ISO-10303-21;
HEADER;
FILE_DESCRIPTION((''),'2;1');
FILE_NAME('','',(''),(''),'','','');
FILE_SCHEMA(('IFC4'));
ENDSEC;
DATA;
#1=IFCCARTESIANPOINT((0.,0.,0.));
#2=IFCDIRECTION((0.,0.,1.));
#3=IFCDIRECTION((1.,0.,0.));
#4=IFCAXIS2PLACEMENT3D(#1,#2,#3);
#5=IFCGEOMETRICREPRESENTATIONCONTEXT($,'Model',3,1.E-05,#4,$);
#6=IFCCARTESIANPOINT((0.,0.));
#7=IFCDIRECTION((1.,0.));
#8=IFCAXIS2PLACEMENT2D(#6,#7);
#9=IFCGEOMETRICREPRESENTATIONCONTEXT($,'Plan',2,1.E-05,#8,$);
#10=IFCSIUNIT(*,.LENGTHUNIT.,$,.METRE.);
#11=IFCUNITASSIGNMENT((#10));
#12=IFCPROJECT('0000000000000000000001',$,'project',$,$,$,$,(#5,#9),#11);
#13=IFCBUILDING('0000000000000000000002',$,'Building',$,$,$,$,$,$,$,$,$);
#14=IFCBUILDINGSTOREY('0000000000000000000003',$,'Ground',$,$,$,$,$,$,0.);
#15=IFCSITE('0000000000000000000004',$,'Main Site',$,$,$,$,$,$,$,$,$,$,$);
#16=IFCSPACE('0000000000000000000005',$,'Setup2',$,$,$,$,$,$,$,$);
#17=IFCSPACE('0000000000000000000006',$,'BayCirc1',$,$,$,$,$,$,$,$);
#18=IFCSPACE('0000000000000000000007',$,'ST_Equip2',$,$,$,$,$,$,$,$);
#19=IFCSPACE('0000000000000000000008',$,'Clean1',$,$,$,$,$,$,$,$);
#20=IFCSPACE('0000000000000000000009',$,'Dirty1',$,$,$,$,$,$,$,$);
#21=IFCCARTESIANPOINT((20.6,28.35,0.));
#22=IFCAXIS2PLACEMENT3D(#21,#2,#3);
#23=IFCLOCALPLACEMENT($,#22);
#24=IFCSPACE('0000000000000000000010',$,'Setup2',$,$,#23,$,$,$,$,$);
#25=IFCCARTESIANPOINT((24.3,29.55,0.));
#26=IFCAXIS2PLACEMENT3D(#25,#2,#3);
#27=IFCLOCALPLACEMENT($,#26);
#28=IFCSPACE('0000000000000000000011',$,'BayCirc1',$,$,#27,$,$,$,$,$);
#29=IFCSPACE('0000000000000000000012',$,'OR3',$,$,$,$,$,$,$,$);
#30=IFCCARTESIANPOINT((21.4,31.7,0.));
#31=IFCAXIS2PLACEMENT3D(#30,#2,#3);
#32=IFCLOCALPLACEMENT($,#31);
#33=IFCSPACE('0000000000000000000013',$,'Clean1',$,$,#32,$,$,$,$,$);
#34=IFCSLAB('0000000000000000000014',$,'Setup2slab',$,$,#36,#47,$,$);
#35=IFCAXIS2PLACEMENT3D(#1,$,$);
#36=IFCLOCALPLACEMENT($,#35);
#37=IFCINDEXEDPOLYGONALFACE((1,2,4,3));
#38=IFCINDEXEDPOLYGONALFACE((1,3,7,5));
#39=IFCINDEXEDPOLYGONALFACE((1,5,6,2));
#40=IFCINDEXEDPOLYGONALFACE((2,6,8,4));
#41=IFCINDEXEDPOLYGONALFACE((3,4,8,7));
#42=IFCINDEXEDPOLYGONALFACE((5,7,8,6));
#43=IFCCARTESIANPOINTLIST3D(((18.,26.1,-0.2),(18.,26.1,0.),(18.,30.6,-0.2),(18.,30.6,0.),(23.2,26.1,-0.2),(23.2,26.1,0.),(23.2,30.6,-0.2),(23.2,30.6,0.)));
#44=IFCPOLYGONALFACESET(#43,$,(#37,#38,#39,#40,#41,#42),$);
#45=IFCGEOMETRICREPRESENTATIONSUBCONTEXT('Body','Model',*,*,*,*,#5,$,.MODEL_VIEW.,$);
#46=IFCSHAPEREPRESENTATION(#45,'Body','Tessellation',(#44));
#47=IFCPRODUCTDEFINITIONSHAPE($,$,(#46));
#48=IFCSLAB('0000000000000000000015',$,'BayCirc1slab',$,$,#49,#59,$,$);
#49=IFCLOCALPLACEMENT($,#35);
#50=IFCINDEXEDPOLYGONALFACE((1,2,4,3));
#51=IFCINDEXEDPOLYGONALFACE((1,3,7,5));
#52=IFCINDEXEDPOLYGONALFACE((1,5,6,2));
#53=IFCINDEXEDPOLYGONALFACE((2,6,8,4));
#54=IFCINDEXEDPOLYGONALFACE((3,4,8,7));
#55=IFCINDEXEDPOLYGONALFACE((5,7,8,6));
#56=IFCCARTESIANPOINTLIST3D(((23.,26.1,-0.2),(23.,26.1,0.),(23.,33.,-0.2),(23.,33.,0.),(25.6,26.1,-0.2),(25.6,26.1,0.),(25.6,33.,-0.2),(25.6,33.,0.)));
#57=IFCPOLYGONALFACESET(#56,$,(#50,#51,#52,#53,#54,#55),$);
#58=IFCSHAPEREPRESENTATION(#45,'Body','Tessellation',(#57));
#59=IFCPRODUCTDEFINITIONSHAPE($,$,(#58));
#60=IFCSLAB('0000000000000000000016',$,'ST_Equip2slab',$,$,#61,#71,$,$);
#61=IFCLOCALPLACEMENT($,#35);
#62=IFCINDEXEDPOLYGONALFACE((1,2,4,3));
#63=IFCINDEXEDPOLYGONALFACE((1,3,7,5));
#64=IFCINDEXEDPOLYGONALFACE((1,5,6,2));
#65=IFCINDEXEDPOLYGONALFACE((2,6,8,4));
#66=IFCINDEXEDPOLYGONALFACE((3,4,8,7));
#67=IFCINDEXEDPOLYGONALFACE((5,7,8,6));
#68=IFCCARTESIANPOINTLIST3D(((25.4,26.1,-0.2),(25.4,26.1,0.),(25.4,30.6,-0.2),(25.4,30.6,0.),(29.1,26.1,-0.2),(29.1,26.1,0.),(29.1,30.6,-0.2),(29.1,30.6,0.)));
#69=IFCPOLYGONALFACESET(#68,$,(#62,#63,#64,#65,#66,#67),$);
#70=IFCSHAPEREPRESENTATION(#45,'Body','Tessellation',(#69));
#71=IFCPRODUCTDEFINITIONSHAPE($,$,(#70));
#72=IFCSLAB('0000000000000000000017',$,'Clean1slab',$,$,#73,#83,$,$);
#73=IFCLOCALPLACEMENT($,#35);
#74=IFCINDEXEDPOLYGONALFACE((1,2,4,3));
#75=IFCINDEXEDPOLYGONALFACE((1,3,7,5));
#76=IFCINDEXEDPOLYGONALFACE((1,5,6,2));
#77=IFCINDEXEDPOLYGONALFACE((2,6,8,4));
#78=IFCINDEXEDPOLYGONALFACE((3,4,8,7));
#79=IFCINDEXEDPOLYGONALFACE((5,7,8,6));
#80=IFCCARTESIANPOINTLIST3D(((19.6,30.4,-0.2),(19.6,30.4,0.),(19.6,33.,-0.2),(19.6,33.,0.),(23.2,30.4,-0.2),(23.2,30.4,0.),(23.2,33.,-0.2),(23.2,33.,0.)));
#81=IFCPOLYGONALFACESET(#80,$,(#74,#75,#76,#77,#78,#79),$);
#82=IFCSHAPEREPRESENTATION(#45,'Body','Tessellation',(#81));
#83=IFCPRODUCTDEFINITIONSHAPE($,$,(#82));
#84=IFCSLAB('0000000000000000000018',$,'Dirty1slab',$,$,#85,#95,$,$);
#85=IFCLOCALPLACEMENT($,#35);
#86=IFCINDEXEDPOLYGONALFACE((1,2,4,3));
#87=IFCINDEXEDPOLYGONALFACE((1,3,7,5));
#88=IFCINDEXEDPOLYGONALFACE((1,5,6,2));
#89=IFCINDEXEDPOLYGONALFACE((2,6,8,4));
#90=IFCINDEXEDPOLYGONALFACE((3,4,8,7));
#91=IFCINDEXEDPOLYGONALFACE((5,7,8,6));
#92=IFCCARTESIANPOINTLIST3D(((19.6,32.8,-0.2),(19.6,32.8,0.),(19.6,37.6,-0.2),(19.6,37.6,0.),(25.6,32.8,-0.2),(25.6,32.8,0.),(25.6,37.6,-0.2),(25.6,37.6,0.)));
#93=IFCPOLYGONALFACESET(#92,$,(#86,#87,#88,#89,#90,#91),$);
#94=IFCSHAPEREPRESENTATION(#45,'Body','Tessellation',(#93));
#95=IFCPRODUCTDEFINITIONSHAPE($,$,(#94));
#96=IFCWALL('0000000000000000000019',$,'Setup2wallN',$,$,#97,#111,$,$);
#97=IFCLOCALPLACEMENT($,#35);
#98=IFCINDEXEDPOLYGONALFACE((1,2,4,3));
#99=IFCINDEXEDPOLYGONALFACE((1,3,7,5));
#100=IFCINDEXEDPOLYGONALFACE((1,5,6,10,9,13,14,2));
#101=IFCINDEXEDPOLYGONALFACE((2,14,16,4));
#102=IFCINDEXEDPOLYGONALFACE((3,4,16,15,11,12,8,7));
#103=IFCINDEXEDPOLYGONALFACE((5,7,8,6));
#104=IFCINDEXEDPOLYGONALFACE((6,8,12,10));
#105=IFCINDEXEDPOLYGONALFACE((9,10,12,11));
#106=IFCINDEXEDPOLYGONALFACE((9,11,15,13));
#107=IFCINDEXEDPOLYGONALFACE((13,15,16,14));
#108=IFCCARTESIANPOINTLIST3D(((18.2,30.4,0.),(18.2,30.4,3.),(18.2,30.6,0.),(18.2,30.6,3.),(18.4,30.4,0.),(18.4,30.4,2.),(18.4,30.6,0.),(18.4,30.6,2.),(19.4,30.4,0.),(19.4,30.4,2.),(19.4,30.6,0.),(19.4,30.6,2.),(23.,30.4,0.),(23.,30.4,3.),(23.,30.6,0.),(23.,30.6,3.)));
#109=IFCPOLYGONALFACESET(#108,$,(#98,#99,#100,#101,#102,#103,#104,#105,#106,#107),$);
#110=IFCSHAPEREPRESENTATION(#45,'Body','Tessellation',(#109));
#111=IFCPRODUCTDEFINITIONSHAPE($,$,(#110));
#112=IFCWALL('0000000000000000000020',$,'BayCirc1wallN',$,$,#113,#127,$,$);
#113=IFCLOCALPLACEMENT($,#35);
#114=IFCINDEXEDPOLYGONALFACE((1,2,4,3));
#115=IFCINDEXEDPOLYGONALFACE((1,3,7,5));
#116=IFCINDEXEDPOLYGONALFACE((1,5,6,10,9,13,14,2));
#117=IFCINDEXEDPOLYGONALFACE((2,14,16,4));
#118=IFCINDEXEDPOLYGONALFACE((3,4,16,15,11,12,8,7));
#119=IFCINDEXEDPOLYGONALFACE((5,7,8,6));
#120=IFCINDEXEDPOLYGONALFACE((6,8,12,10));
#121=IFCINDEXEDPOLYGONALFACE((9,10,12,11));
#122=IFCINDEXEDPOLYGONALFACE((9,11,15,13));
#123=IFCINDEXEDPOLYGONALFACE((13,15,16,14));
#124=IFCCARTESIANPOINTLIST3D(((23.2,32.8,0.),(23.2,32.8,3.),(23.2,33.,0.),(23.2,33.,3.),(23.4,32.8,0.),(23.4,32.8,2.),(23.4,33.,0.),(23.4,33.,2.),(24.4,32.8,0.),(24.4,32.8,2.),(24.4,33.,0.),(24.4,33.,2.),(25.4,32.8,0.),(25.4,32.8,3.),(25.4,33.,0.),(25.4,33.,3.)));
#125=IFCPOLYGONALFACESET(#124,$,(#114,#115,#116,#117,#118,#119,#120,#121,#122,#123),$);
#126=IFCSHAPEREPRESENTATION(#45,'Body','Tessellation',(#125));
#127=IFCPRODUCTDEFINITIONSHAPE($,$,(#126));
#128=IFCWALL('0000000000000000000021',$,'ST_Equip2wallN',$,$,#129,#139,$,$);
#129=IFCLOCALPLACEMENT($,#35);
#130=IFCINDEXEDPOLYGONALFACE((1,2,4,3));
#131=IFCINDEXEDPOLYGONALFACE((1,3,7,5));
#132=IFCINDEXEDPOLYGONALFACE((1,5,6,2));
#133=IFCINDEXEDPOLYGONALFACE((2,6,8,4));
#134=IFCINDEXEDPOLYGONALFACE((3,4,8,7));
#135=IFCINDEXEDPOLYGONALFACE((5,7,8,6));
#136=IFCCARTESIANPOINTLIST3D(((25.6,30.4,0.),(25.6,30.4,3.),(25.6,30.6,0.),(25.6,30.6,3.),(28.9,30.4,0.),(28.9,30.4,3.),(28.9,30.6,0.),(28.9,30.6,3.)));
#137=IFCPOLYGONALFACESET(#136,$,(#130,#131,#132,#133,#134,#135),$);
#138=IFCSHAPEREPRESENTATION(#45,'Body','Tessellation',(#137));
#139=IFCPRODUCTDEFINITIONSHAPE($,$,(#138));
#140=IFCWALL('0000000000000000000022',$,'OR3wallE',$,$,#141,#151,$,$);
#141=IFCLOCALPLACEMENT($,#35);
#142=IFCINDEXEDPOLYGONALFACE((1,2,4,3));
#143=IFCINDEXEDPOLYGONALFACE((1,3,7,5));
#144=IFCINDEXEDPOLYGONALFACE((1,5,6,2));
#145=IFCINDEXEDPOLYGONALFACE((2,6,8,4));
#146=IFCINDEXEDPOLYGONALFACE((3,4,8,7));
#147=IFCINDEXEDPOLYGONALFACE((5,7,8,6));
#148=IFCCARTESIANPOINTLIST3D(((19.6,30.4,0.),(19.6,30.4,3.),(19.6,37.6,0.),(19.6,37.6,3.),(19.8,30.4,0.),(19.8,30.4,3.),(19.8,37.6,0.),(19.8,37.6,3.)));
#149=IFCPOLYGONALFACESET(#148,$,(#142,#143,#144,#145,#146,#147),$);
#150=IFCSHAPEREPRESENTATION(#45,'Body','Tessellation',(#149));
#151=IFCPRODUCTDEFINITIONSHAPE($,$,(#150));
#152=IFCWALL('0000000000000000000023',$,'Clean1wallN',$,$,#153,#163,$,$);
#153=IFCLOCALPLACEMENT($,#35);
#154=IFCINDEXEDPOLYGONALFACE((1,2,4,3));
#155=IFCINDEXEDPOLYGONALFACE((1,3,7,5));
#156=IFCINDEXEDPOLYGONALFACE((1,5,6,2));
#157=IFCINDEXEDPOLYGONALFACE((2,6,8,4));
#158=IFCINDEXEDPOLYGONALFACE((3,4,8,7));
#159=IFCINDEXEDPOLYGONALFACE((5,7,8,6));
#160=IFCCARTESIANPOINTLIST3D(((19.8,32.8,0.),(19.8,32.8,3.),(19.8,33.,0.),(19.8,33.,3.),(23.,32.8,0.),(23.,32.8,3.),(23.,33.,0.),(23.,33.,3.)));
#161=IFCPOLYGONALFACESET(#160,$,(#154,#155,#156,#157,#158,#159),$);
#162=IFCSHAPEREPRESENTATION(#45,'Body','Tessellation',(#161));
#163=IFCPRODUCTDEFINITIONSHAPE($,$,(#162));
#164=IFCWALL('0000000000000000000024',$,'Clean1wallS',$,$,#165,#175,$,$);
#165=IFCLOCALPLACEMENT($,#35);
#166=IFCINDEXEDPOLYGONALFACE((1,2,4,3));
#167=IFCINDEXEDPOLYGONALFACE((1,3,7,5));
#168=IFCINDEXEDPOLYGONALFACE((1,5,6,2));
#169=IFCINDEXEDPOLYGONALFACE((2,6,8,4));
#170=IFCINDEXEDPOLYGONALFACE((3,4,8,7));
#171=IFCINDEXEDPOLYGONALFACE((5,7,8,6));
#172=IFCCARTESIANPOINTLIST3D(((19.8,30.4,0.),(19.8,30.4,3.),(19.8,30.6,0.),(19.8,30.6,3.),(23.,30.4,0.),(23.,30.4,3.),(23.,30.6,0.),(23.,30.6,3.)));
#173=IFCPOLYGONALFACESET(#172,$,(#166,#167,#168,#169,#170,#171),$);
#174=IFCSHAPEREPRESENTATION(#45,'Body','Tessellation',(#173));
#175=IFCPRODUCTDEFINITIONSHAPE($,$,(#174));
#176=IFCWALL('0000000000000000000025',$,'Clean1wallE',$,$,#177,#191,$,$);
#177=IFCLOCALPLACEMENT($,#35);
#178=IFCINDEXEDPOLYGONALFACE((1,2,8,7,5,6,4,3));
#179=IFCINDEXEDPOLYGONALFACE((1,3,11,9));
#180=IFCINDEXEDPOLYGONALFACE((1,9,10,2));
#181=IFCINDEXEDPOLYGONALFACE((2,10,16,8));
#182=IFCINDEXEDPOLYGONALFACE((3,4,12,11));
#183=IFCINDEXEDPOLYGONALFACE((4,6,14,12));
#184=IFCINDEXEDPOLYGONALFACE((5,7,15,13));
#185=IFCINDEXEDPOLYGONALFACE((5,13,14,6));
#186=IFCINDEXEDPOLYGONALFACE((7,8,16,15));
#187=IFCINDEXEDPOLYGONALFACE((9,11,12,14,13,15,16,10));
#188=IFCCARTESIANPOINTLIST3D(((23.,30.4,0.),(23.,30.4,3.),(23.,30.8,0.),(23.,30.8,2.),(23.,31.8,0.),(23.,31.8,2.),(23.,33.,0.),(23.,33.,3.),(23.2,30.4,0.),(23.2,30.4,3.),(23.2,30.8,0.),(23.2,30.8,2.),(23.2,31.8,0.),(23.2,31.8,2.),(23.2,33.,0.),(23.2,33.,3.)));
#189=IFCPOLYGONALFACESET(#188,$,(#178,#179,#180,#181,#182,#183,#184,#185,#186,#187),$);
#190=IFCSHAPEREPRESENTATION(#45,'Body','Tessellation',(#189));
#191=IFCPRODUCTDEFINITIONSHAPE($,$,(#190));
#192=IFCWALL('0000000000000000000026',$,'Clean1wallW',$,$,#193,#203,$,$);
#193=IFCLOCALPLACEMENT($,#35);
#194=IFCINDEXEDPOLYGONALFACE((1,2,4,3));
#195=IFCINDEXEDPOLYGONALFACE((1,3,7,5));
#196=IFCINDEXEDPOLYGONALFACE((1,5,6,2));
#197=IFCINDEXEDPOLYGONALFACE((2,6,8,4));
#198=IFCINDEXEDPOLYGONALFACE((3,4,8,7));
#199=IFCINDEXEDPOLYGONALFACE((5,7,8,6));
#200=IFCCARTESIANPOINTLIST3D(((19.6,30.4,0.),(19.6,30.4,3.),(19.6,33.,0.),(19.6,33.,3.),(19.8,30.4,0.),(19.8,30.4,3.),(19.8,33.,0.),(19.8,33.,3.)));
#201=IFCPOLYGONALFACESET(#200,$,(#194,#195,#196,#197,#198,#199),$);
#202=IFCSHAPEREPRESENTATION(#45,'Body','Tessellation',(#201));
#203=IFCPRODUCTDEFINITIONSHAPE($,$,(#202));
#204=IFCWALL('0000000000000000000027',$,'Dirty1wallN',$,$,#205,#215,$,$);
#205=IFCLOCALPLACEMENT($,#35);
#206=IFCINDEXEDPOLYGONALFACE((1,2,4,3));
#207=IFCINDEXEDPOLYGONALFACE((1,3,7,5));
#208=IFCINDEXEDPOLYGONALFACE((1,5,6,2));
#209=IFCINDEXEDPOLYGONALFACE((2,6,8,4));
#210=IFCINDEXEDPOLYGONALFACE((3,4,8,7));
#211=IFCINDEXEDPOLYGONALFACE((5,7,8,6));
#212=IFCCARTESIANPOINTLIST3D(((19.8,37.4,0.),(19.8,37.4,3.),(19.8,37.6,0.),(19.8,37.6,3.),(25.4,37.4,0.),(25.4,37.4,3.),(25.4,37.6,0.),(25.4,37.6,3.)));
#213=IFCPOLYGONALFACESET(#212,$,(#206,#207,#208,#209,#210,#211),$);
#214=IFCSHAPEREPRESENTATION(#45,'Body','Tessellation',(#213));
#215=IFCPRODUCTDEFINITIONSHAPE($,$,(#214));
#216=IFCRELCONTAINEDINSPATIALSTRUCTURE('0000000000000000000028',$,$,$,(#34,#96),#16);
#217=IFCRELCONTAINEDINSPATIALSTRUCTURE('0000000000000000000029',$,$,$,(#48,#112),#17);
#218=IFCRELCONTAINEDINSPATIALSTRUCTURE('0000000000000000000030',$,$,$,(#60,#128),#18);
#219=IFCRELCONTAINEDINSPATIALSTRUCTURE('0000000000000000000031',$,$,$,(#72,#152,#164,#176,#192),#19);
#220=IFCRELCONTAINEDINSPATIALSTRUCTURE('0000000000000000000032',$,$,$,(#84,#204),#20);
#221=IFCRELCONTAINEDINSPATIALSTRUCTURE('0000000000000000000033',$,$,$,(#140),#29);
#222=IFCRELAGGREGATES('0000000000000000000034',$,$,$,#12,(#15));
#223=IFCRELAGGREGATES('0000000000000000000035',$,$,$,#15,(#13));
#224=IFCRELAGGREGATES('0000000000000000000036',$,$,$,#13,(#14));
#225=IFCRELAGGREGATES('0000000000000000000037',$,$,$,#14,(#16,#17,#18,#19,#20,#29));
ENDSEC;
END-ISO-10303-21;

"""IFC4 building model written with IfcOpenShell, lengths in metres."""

from ifc_helpers import new_model, si_unit, frame, origin_with_axes, origin_2d_with_axis, place, context, subcontext, project, spatial, indexed_curve, rectangle, outline, extrude, element, save


model = new_model("IFC4")

# Units and contexts
model_context = context("Model", 3, precision=1e-05, world=origin_with_axes())
plan_context = context("Plan", 2, precision=1e-05, world=origin_2d_with_axis())
body_context = subcontext(model_context, "Body", "Model", "MODEL_VIEW")
ifc_project = project(units=[si_unit("LENGTHUNIT", "METRE")], contexts=[model_context, plan_context])

# Site, building, storey, space
site = spatial("IfcSite", under=ifc_project, Name="Main Site")
building = spatial("IfcBuilding", under=site, Name="Building")
storey = spatial("IfcBuildingStorey", under=building, Name="Ground", Elevation=0.0)
space_1 = spatial("IfcSpace", under=storey, Name="Setup2")

# Slab
slab_1_placement = place(None, frame((20.6, 28.35, -0.2), z_axis=(0.0, 0.0, 1.0), x_axis=(1.0, 0.0, 0.0)))
element("IfcSlab", 1, at=slab_1_placement, inside=space_1, Name="Setup2slab", context=body_context, shape_type="SweptSolid", body=[
    extrude(rectangle(XDim=5.2, YDim=4.5), origin_with_axes(), (0.0, 0.0, 1.0), 0.2),
])

# Shared definitions
space_2 = spatial("IfcSpace", under=storey, Name="BayCirc1")

# Slab
slab_2_placement = place(None, frame((24.3, 29.55, -0.2), z_axis=(0.0, 0.0, 1.0), x_axis=(1.0, 0.0, 0.0)))
element("IfcSlab", 2, at=slab_2_placement, inside=space_2, Name="BayCirc1slab", context=body_context, shape_type="SweptSolid", body=[
    extrude(rectangle(XDim=2.6, YDim=6.9), origin_with_axes(), (0.0, 0.0, 1.0), 0.2),
])

# Shared definitions
space_3 = spatial("IfcSpace", under=storey, Name="ST_Equip2")

# Slab
slab_3_placement = place(None, frame((27.25, 28.35, -0.2), z_axis=(0.0, 0.0, 1.0), x_axis=(1.0, 0.0, 0.0)))
element("IfcSlab", 3, at=slab_3_placement, inside=space_3, Name="ST_Equip2slab", context=body_context, shape_type="SweptSolid", body=[
    extrude(rectangle(XDim=3.7, YDim=4.5), origin_with_axes(), (0.0, 0.0, 1.0), 0.2),
])

# Shared definitions
space_4 = spatial("IfcSpace", under=storey, Name="Clean1")

# Slab
slab_4_placement = place(None, frame((21.4, 31.7, -0.2), z_axis=(0.0, 0.0, 1.0), x_axis=(1.0, 0.0, 0.0)))
element("IfcSlab", 4, at=slab_4_placement, inside=space_4, Name="Clean1slab", context=body_context, shape_type="SweptSolid", body=[
    extrude(rectangle(XDim=3.6, YDim=2.6), origin_with_axes(), (0.0, 0.0, 1.0), 0.2),
])

# Shared definitions
space_5 = spatial("IfcSpace", under=storey, Name="Dirty1")

# Slab
slab_5_placement = place(None, frame((22.6, 35.2, -0.2), z_axis=(0.0, 0.0, 1.0), x_axis=(1.0, 0.0, 0.0)))
element("IfcSlab", 5, at=slab_5_placement, inside=space_5, Name="Dirty1slab", context=body_context, shape_type="SweptSolid", body=[
    extrude(rectangle(XDim=6.0, YDim=4.8), origin_with_axes(), (0.0, 0.0, 1.0), 0.2),
])

# Wall
wall_1_placement = place(None, frame((18.2, 30.4, 0.0), z_axis=(0.0, 0.0, 1.0), x_axis=(1.0, 0.0, 0.0)))
wall_1 = element("IfcWall", 6, at=wall_1_placement, inside=space_1, Name="Setup2wallN", context=body_context, shape_type="SweptSolid", body=[
    extrude(outline(indexed_curve([(0.0, 0.0), (0.0, 0.2), (4.8, 0.2), (4.8, 0.0), (0.0, 0.0)], self_intersect=False)), origin_with_axes(), (0.0, 0.0, 1.0), 3.0),
])

# Shared definitions
space_6_placement = place(None, frame((20.6, 28.35, 0.0), z_axis=(0.0, 0.0, 1.0), x_axis=(1.0, 0.0, 0.0)))
space_6 = spatial("IfcSpace", at=space_6_placement, Name="Setup2")

# Opening
opening_1_placement = place(wall_1_placement, frame((0.2, 0.0, 0.0), z_axis=(0.0, 0.0, 1.0), x_axis=(1.0, 0.0, 0.0)))
element("IfcOpeningElement", 7, at=opening_1_placement, inside=space_6, cuts=wall_1, context=body_context, shape_type="SweptSolid", body=[
    extrude(outline(indexed_curve([(0.0, 0.0), (0.0, 0.4), (1.0, 0.4), (1.0, 0.0), (0.0, 0.0)], self_intersect=False)), origin_with_axes(), (0.0, 0.0, 1.0), 2.0),
])

# Wall
wall_2_placement = place(None, frame((23.2, 32.8, 0.0), z_axis=(0.0, 0.0, 1.0), x_axis=(1.0, 0.0, 0.0)))
wall_2 = element("IfcWall", 8, at=wall_2_placement, inside=space_2, Name="BayCirc1wallN", context=body_context, shape_type="SweptSolid", body=[
    extrude(outline(indexed_curve([(0.0, 0.0), (0.0, 0.2), (2.2, 0.2), (2.2, 0.0), (0.0, 0.0)], self_intersect=False)), origin_with_axes(), (0.0, 0.0, 1.0), 3.0),
])

# Shared definitions
space_7_placement = place(None, frame((24.3, 29.55, 0.0), z_axis=(0.0, 0.0, 1.0), x_axis=(1.0, 0.0, 0.0)))
space_7 = spatial("IfcSpace", at=space_7_placement, Name="BayCirc1")

# Opening
opening_2_placement = place(wall_2_placement, frame((0.2, 0.0, 0.0), z_axis=(0.0, 0.0, 1.0), x_axis=(1.0, 0.0, 0.0)))
element("IfcOpeningElement", 9, at=opening_2_placement, inside=space_7, cuts=wall_2, context=body_context, shape_type="SweptSolid", body=[
    extrude(outline(indexed_curve([(0.0, 0.0), (0.0, 0.4), (1.0, 0.4), (1.0, 0.0), (0.0, 0.0)], self_intersect=False)), origin_with_axes(), (0.0, 0.0, 1.0), 2.0),
])

# Wall
wall_3_placement = place(None, frame((25.6, 30.4, 0.0), z_axis=(0.0, 0.0, 1.0), x_axis=(1.0, 0.0, 0.0)))
element("IfcWall", 10, at=wall_3_placement, inside=space_3, Name="ST_Equip2wallN", context=body_context, shape_type="SweptSolid", body=[
    extrude(outline(indexed_curve([(0.0, 0.0), (0.0, 0.2), (3.3, 0.2), (3.3, 0.0), (0.0, 0.0)], self_intersect=False)), origin_with_axes(), (0.0, 0.0, 1.0), 3.0),
])

# Shared definitions
space_8 = spatial("IfcSpace", under=storey, Name="OR3")

# Walls
wall_4_placement = place(None, frame((19.8, 30.4, 0.0), z_axis=(0.0, 0.0, 1.0), x_axis=(0.0, 1.0, 0.0)))
element("IfcWall", 11, at=wall_4_placement, inside=space_8, Name="OR3wallE", context=body_context, shape_type="SweptSolid", body=[
    extrude(outline(indexed_curve([(0.0, 0.0), (0.0, 0.2), (7.2, 0.2), (7.2, 0.0), (0.0, 0.0)], self_intersect=False)), origin_with_axes(), (0.0, 0.0, 1.0), 3.0),
])
for number, where, z_axis, x_axis, name in (
    (12, (19.8, 32.8, 0.0), (0.0, 0.0, 1.0), (1.0, 0.0, 0.0), "Clean1wallN"),
    (13, (19.8, 30.4, 0.0), (0.0, 0.0, 1.0), (1.0, 0.0, 0.0), "Clean1wallS"),
):
    element("IfcWall", number, at=place(None, frame(where, z_axis=z_axis, x_axis=x_axis)), inside=space_4, Name=name, context=body_context, shape_type="SweptSolid", body=[
        extrude(outline(indexed_curve([(0.0, 0.0), (0.0, 0.2), (3.2, 0.2), (3.2, 0.0), (0.0, 0.0)], self_intersect=False)), origin_with_axes(), (0.0, 0.0, 1.0), 3.0),
    ])

# Wall
wall_5_placement = place(None, frame((23.2, 30.4, 0.0), z_axis=(0.0, 0.0, 1.0), x_axis=(0.0, 1.0, 0.0)))
wall_5 = element("IfcWall", 14, at=wall_5_placement, inside=space_4, Name="Clean1wallE", context=body_context, shape_type="SweptSolid", body=[
    extrude(outline(indexed_curve([(0.0, 0.0), (0.0, 0.2), (2.6, 0.2), (2.6, 0.0), (0.0, 0.0)], self_intersect=False)), origin_with_axes(), (0.0, 0.0, 1.0), 3.0),
])

# Shared definitions
space_9_placement = place(None, frame((21.4, 31.7, 0.0), z_axis=(0.0, 0.0, 1.0), x_axis=(1.0, 0.0, 0.0)))
space_9 = spatial("IfcSpace", at=space_9_placement, Name="Clean1")

# Opening
opening_3_placement = place(wall_5_placement, frame((0.4, 0.0, 0.0), z_axis=(0.0, 0.0, 1.0), x_axis=(1.0, 0.0, 0.0)))
element("IfcOpeningElement", 15, at=opening_3_placement, inside=space_9, cuts=wall_5, context=body_context, shape_type="SweptSolid", body=[
    extrude(outline(indexed_curve([(0.0, 0.0), (0.0, 0.4), (1.0, 0.4), (1.0, 0.0), (0.0, 0.0)], self_intersect=False)), origin_with_axes(), (0.0, 0.0, 1.0), 2.0),
])

# Walls
wall_6_placement = place(None, frame((19.8, 30.4, 0.0), z_axis=(0.0, 0.0, 1.0), x_axis=(0.0, 1.0, 0.0)))
element("IfcWall", 16, at=wall_6_placement, inside=space_4, Name="Clean1wallW", context=body_context, shape_type="SweptSolid", body=[
    extrude(outline(indexed_curve([(0.0, 0.0), (0.0, 0.2), (2.6, 0.2), (2.6, 0.0), (0.0, 0.0)], self_intersect=False)), origin_with_axes(), (0.0, 0.0, 1.0), 3.0),
])
wall_7_placement = place(None, frame((19.8, 37.4, 0.0), z_axis=(0.0, 0.0, 1.0), x_axis=(1.0, 0.0, 0.0)))
element("IfcWall", 17, at=wall_7_placement, inside=space_5, Name="Dirty1wallN", context=body_context, shape_type="SweptSolid", body=[
    extrude(outline(indexed_curve([(0.0, 0.0), (0.0, 0.2), (5.6, 0.2), (5.6, 0.0), (0.0, 0.0)], self_intersect=False)), origin_with_axes(), (0.0, 0.0, 1.0), 3.0),
])

save(model, "model.ifc")
